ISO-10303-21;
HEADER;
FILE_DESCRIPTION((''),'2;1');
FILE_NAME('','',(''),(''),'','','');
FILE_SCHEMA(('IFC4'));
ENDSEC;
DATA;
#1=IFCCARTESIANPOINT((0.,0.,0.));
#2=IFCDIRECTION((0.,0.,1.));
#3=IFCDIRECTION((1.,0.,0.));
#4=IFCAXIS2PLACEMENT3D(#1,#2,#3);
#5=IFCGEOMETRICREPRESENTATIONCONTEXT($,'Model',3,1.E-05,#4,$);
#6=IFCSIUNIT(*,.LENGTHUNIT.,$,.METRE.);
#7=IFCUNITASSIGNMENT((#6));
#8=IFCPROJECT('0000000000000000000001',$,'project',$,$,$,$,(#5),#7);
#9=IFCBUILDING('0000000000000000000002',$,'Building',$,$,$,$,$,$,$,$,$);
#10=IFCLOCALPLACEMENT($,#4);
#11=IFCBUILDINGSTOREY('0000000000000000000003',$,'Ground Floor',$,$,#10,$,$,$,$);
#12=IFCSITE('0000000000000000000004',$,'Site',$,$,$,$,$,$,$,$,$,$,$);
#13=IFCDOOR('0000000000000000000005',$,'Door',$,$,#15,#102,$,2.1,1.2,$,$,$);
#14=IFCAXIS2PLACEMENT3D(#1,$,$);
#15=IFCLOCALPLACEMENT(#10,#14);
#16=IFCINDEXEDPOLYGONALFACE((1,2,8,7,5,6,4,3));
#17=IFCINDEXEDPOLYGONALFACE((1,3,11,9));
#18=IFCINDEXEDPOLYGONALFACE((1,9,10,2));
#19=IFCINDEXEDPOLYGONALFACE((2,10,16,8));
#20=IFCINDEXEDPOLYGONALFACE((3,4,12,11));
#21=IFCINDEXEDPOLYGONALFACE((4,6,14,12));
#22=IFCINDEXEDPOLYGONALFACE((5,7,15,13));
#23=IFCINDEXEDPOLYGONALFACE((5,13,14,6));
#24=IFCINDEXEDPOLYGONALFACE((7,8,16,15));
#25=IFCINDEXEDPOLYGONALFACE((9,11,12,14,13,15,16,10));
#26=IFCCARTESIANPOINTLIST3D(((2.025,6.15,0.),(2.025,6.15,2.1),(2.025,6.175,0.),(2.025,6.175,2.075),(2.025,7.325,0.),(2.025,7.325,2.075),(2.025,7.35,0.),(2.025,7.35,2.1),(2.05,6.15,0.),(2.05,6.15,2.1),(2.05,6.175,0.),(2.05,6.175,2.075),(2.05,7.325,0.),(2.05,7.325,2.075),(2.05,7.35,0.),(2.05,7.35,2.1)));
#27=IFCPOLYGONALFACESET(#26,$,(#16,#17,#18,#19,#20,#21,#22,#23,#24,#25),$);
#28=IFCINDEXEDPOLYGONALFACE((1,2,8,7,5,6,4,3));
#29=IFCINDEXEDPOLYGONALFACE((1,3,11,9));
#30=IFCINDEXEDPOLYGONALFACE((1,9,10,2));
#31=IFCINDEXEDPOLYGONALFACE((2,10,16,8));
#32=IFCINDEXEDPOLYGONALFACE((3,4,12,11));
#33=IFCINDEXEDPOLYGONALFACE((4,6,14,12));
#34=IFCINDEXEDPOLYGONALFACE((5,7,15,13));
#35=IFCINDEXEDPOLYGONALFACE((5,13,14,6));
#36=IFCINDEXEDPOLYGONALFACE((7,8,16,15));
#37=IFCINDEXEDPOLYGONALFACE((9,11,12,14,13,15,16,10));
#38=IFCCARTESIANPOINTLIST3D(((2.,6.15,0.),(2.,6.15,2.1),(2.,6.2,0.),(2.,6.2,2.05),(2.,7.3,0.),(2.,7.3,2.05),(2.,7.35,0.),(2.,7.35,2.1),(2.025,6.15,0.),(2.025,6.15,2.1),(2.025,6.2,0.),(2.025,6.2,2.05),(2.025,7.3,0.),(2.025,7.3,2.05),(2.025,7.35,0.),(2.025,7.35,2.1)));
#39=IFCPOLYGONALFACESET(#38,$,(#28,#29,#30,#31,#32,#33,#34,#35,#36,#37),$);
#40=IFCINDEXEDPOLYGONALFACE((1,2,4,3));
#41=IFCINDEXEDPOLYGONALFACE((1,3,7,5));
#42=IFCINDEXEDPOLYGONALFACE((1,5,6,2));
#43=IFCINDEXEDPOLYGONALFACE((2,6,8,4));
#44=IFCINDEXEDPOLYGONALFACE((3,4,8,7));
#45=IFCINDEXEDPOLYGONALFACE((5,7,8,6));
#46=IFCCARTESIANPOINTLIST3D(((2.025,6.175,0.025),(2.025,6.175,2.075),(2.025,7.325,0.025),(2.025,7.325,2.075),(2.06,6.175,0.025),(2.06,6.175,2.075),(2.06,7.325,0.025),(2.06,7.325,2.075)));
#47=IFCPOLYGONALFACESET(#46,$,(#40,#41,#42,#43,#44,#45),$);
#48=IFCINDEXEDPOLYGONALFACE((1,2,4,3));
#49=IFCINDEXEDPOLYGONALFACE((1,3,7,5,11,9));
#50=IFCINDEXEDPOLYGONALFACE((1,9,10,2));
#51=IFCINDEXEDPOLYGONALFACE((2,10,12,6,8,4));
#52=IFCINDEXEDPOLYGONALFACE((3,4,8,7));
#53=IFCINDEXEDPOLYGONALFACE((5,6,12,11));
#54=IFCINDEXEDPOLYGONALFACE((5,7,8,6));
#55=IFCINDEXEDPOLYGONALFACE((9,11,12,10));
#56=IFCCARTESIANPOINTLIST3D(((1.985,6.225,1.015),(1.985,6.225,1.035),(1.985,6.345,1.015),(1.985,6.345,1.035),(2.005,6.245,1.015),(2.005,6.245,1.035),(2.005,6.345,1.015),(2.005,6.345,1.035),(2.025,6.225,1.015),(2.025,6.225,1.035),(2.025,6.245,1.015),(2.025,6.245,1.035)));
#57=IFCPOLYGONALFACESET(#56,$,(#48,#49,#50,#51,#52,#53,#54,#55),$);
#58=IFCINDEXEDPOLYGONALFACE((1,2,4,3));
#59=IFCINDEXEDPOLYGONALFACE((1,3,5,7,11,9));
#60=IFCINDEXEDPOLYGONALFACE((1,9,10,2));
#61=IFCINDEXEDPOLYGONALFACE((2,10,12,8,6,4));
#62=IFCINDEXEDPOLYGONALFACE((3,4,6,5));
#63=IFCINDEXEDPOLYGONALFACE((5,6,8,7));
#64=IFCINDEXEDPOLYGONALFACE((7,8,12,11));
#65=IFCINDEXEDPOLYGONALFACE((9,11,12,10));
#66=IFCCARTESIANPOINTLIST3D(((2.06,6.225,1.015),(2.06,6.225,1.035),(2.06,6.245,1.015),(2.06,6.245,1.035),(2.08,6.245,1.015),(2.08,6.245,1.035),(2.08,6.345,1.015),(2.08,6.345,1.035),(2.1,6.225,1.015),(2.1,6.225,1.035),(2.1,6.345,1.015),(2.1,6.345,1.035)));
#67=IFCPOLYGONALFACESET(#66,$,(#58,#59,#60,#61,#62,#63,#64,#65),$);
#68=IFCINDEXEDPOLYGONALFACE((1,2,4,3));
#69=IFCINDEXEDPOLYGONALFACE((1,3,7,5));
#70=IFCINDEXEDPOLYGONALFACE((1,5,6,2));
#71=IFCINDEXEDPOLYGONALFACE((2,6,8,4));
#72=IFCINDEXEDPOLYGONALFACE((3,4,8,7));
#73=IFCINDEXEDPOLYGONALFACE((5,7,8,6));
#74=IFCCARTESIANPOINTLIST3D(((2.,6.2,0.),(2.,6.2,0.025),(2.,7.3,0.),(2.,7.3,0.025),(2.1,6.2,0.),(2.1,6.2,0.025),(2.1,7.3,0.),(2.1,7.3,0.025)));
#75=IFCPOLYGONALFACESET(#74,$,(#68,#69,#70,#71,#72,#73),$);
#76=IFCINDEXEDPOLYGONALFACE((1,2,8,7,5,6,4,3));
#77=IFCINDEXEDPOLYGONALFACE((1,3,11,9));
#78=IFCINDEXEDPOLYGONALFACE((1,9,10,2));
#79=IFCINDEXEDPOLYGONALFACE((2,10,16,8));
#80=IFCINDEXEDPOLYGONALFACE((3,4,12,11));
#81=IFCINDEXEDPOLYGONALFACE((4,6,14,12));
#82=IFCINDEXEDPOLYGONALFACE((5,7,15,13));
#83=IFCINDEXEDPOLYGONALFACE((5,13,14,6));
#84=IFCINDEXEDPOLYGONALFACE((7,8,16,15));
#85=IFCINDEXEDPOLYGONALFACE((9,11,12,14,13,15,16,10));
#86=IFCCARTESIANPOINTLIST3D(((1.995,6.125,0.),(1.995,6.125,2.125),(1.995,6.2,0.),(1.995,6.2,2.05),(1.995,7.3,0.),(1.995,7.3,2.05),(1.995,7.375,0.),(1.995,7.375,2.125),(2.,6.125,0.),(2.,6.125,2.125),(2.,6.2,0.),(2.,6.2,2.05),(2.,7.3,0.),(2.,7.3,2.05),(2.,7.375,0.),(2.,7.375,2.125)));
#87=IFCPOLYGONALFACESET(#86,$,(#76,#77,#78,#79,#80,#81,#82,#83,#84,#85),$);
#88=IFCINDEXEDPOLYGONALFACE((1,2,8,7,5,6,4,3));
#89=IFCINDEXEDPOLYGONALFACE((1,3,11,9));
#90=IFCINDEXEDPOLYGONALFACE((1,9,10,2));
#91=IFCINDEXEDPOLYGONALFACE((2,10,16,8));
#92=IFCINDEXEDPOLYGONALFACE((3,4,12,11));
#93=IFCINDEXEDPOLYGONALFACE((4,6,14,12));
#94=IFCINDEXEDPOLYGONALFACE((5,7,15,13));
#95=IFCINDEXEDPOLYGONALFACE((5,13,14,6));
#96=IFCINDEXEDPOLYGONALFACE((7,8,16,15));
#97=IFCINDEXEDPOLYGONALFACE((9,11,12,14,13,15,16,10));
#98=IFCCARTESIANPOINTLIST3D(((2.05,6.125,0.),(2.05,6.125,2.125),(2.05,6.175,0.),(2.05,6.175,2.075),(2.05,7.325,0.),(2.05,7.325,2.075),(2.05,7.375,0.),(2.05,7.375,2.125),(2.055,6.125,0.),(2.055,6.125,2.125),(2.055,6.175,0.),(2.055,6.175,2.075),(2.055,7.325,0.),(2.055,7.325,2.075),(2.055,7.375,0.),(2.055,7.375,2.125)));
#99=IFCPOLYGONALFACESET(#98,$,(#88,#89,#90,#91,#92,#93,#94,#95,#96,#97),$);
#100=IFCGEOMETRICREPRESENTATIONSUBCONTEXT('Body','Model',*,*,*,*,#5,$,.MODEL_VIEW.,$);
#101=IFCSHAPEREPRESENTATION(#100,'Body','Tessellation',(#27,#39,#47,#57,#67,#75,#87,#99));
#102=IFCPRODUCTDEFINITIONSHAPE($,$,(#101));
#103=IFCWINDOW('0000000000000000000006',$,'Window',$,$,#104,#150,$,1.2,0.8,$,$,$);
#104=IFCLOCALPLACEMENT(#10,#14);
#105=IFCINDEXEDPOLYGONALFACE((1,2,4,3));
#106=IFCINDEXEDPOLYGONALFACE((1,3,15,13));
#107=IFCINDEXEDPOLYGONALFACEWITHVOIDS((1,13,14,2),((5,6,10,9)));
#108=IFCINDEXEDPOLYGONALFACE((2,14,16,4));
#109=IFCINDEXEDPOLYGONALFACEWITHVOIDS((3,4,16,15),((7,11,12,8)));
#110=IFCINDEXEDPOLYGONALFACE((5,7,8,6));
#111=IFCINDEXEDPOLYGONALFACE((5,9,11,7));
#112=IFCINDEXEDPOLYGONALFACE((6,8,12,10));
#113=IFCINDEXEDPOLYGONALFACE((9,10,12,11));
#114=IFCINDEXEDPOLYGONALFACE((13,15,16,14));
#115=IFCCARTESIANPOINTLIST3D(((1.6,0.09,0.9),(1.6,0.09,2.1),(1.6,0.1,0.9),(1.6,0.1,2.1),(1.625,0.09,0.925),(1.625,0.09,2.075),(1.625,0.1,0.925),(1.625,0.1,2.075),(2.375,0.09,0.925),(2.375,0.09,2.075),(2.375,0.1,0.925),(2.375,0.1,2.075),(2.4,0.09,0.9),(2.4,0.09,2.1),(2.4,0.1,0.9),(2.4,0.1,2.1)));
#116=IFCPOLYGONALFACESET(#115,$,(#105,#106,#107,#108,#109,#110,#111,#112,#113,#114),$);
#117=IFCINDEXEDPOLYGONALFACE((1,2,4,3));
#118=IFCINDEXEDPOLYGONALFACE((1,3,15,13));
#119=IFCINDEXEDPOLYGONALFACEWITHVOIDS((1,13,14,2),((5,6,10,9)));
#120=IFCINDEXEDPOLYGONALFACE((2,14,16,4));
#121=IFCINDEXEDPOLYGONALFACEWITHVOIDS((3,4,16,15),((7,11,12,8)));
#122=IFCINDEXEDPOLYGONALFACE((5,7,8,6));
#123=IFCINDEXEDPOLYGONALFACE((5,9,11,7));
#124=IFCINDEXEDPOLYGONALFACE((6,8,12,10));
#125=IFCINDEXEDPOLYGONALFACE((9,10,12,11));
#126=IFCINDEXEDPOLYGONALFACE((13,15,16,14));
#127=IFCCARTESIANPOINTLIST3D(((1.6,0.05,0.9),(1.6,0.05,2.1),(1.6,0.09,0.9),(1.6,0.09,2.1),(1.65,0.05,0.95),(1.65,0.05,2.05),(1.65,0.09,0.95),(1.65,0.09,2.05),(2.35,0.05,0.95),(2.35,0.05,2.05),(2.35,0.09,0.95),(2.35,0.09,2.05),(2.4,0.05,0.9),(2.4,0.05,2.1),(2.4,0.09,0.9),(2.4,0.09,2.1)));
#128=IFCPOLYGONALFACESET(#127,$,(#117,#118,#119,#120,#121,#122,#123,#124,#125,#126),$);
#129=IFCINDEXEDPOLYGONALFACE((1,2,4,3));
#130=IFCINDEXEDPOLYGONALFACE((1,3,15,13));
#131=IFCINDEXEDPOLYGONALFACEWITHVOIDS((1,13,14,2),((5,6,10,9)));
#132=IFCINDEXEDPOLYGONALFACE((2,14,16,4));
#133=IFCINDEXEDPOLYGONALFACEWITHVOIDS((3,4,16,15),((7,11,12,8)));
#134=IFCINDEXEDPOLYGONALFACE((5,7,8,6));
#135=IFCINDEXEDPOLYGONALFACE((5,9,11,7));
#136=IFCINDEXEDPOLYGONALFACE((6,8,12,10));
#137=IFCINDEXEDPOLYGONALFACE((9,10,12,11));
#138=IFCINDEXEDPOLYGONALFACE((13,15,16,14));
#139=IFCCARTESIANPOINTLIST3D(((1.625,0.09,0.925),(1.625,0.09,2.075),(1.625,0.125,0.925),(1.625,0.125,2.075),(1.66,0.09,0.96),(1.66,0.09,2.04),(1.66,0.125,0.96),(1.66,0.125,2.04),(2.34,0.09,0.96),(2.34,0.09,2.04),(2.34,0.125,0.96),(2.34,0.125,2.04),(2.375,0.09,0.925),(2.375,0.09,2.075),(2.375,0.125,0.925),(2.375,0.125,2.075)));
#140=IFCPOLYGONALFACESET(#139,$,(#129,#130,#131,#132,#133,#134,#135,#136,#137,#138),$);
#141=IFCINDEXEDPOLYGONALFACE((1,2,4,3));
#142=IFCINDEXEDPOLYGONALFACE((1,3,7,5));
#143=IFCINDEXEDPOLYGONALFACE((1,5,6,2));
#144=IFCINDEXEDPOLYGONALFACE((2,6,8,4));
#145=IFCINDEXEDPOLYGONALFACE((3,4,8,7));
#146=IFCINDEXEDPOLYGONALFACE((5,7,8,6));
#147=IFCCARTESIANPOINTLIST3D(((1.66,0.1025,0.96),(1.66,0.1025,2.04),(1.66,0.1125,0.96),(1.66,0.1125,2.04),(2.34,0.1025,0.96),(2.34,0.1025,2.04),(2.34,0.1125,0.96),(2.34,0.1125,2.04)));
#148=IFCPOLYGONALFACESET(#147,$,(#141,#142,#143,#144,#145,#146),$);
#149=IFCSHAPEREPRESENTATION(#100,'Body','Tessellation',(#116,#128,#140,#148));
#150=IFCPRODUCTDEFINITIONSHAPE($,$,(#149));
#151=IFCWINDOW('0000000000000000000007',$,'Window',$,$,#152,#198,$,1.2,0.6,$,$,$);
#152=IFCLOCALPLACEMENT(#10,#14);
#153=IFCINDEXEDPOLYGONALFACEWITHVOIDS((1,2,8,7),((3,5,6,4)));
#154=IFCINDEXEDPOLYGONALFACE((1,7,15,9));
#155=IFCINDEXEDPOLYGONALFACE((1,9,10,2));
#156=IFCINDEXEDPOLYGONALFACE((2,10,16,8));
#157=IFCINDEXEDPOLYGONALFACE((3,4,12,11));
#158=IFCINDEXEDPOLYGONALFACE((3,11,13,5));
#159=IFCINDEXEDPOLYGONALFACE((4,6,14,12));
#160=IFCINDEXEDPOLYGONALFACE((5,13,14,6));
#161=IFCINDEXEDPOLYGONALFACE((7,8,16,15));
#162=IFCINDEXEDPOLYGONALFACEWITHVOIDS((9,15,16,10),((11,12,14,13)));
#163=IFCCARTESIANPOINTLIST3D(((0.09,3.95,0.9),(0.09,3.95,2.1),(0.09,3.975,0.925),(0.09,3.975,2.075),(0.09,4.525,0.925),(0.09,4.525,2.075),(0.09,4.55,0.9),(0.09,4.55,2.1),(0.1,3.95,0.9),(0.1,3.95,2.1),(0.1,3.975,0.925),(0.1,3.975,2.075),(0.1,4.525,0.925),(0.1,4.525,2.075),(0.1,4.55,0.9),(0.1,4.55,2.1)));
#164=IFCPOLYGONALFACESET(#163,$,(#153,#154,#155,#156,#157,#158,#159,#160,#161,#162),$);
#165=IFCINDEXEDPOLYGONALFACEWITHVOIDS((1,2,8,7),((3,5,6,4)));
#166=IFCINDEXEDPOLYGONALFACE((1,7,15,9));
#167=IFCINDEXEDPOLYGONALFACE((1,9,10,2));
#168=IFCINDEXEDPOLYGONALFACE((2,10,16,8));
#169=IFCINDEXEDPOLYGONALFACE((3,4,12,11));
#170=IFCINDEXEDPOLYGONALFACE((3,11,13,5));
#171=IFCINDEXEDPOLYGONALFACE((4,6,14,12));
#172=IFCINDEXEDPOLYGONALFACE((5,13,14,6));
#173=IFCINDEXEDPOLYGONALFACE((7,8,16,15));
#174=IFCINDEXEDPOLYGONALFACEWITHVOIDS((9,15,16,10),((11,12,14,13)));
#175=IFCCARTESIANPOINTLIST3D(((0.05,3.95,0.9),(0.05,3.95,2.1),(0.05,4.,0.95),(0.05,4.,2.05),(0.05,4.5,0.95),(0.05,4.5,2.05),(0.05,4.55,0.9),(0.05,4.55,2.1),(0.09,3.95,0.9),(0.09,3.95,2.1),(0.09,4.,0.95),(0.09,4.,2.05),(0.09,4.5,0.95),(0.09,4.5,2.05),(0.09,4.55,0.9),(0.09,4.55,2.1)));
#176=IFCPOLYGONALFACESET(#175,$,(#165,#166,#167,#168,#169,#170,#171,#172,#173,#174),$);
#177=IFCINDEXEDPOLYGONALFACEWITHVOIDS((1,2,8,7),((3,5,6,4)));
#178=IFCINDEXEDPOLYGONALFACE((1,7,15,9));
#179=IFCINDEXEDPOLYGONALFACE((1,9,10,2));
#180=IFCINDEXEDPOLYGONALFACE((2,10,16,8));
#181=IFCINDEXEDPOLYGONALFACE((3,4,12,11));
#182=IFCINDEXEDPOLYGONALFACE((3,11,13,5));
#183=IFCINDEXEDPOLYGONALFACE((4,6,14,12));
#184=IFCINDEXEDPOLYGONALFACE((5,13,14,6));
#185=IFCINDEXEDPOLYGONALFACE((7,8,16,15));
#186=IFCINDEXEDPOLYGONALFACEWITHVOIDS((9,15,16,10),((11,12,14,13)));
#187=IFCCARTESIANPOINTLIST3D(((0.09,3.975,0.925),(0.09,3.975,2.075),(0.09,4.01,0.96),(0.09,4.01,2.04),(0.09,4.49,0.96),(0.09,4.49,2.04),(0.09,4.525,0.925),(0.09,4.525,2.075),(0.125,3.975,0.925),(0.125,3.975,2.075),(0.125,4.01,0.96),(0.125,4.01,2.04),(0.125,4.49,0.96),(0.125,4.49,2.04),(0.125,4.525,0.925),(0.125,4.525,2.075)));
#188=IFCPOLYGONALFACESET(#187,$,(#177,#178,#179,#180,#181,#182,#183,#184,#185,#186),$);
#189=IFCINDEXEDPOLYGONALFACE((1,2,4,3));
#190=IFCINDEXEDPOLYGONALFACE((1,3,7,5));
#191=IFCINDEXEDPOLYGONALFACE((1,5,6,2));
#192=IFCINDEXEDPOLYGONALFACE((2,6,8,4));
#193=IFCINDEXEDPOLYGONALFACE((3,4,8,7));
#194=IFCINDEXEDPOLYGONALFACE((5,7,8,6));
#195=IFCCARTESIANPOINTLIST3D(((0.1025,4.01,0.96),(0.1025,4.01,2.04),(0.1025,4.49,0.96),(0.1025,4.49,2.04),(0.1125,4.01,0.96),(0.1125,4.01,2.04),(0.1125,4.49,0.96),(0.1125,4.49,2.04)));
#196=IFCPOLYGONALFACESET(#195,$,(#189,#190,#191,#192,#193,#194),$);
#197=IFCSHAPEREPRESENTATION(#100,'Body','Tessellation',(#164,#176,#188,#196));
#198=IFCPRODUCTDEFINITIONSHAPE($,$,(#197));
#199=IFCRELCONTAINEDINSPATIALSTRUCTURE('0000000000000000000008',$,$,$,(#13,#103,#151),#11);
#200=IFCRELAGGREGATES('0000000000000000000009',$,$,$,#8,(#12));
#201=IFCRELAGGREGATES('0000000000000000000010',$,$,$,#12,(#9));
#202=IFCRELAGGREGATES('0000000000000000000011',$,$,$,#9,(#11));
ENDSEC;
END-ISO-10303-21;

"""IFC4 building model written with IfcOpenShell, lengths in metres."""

from ifc_helpers import new_model, si_unit, frame, origin_with_axes, place, context, subcontext, project, spatial, line, indexed_curve, outline, extrude, element, save


model = new_model("IFC4")

# Units and contexts
model_context = context("Model", 3, precision=1e-05, world=origin_with_axes())
body_context = subcontext(model_context, "Body", "Model", "MODEL_VIEW")
ifc_project = project(units=[si_unit("LENGTHUNIT", "METRE")], contexts=[model_context])

# Site, building, storey
site = spatial("IfcSite", under=ifc_project, Name="Site")
building = spatial("IfcBuilding", under=site, Name="Building")
storey_placement = place(None, origin_with_axes())
storey = spatial("IfcBuildingStorey", under=building, at=storey_placement, Name="Ground Floor")

# Door
door_1_placement = place(storey_placement, frame((2.0, 7.35, 0.0), z_axis=(0.0, 0.0, 1.0), x_axis=(0.0, -1.0, 0.0)))
element("IfcDoor", 1, at=door_1_placement, inside=storey, Name="Door", OverallHeight=2.1, OverallWidth=1.2, context=body_context, shape_type="SweptSolid", body=[
    extrude(outline(indexed_curve([(0.0, 0.0), (0.0, 2.1), (1.2, 2.1), (1.2, 0.0), (1.175, 0.0), (1.175, 2.075), (0.025, 2.075), (0.025, 0.0)], segments=[line(1, 2, 3, 4, 5, 6, 7, 8, 1)])), frame((0.0, 0.025, 0.0), z_axis=(0.0, -1.0, 0.0), x_axis=(1.0, 0.0, 0.0)), (0.0, 0.0, -1.0), 0.025),
    extrude(outline(indexed_curve([(0.0, 0.0), (0.0, 2.1), (1.2, 2.1), (1.2, 0.0), (1.15, 0.0), (1.15, 2.05), (0.05, 2.05), (0.05, 0.0)], segments=[line(1, 2, 3, 4, 5, 6, 7, 8, 1)])), frame((0.0, 0.0, 0.0), z_axis=(0.0, -1.0, 0.0), x_axis=(1.0, 0.0, 0.0)), (0.0, 0.0, -1.0), 0.025),
    extrude(outline(indexed_curve([(0.0, 0.0), (1.15, 0.0), (1.15, 0.035), (0.0, 0.035)], segments=[line(1, 2, 3, 4, 1)])), frame((0.025, 0.025, 0.025), z_axis=(0.0, 0.0, 1.0), x_axis=(1.0, 0.0, 0.0)), (0.0, 0.0, 1.0), 2.05),
    extrude(outline(indexed_curve([(0.0, 0.0), (0.0, -0.04), (-0.12, -0.04), (-0.12, -0.02), (-0.02, -0.02), (-0.02, 0.0)], segments=[line(1, 2, 3, 4, 5, 6, 1)])), frame((1.125, 0.025, 1.015), z_axis=(0.0, 0.0, 1.0), x_axis=(1.0, 0.0, 0.0)), (0.0, 0.0, 1.0), 0.02),
    extrude(outline(indexed_curve([(0.0, 0.0), (0.0, 0.04), (-0.12, 0.04), (-0.12, 0.02), (-0.02, 0.02), (-0.02, 0.0)], segments=[line(1, 2, 3, 4, 5, 6, 1)])), frame((1.125, 0.06, 1.015), z_axis=(0.0, 0.0, 1.0), x_axis=(1.0, 0.0, 0.0)), (0.0, 0.0, 1.0), 0.02),
    extrude(outline(indexed_curve([(0.0, 0.0), (1.1, 0.0), (1.1, 0.1), (0.0, 0.1)], segments=[line(1, 2, 3, 4, 1)])), frame((0.05, 0.0, 0.0), z_axis=(0.0, 0.0, 1.0), x_axis=(1.0, 0.0, 0.0)), (0.0, 0.0, 1.0), 0.025),
    extrude(outline(indexed_curve([(0.0, 0.0), (0.0, 2.125), (1.25, 2.125), (1.25, 0.0), (1.175, 0.0), (1.175, 2.05), (0.075, 2.05), (0.075, 0.0)], segments=[line(1, 2, 3, 4, 5, 6, 7, 8, 1)])), frame((-0.025, -0.005, 0.0), z_axis=(0.0, -1.0, 0.0), x_axis=(1.0, 0.0, 0.0)), (0.0, 0.0, -1.0), 0.005),
    extrude(outline(indexed_curve([(0.0, 0.0), (0.0, 2.125), (1.25, 2.125), (1.25, 0.0), (1.2, 0.0), (1.2, 2.075), (0.05, 2.075), (0.05, 0.0)], segments=[line(1, 2, 3, 4, 5, 6, 7, 8, 1)])), frame((-0.025, 0.05, 0.0), z_axis=(0.0, -1.0, 0.0), x_axis=(1.0, 0.0, 0.0)), (0.0, 0.0, -1.0), 0.005),
])

# Windows
window_1_placement = place(storey_placement, frame((1.6, 0.0, 0.9), z_axis=(0.0, 0.0, 1.0), x_axis=(1.0, 0.0, 0.0)))
element("IfcWindow", 2, at=window_1_placement, inside=storey, Name="Window", OverallHeight=1.2, OverallWidth=0.8, context=body_context, shape_type="SweptSolid", body=[
    extrude(outline(indexed_curve([(0.0, 0.0), (0.8, 0.0), (0.8, 1.2), (0.0, 1.2)], segments=[line(1, 2, 3, 4, 1)]), holes=[indexed_curve([(0.025, 0.025), (0.775, 0.025), (0.775, 1.175), (0.025, 1.175)], segments=[line(1, 2, 3, 4, 1)])]), frame((0.0, 0.09, 0.0), z_axis=(0.0, -1.0, 0.0), x_axis=(1.0, 0.0, 0.0)), (0.0, 0.0, -1.0), 0.01),
    extrude(outline(indexed_curve([(0.0, 0.0), (0.8, 0.0), (0.8, 1.2), (0.0, 1.2)], segments=[line(1, 2, 3, 4, 1)]), holes=[indexed_curve([(0.05, 0.05), (0.75, 0.05), (0.75, 1.15), (0.05, 1.15)], segments=[line(1, 2, 3, 4, 1)])]), frame((0.0, 0.05, 0.0), z_axis=(0.0, -1.0, 0.0), x_axis=(1.0, 0.0, 0.0)), (0.0, 0.0, -1.0), 0.04),
    extrude(outline(indexed_curve([(0.0, 0.0), (0.75, 0.0), (0.75, 1.15), (0.0, 1.15)], segments=[line(1, 2, 3, 4, 1)]), holes=[indexed_curve([(0.035, 0.035), (0.715, 0.035), (0.715, 1.115), (0.035, 1.115)], segments=[line(1, 2, 3, 4, 1)])]), frame((0.025, 0.09, 0.025), z_axis=(0.0, -1.0, 0.0), x_axis=(1.0, 0.0, 0.0)), (0.0, 0.0, -1.0), 0.035),
    extrude(outline(indexed_curve([(0.035, 0.035), (0.715, 0.035), (0.715, 1.115), (0.035, 1.115)], segments=[line(1, 2, 3, 4, 1)])), frame((0.025, 0.1025, 0.025), z_axis=(0.0, -1.0, 0.0), x_axis=(1.0, 0.0, 0.0)), (0.0, 0.0, -1.0), 0.01),
])
window_2_placement = place(storey_placement, frame((0.0, 4.55, 0.9), z_axis=(0.0, 0.0, 1.0), x_axis=(0.0, -1.0, 0.0)))
element("IfcWindow", 3, at=window_2_placement, inside=storey, Name="Window", OverallHeight=1.2, OverallWidth=0.6, context=body_context, shape_type="SweptSolid", body=[
    extrude(outline(indexed_curve([(0.0, 0.0), (0.6, 0.0), (0.6, 1.2), (0.0, 1.2)], segments=[line(1, 2, 3, 4, 1)]), holes=[indexed_curve([(0.025, 0.025), (0.575, 0.025), (0.575, 1.175), (0.025, 1.175)], segments=[line(1, 2, 3, 4, 1)])]), frame((0.0, 0.09, 0.0), z_axis=(0.0, -1.0, 0.0), x_axis=(1.0, 0.0, 0.0)), (0.0, 0.0, -1.0), 0.01),
    extrude(outline(indexed_curve([(0.0, 0.0), (0.6, 0.0), (0.6, 1.2), (0.0, 1.2)], segments=[line(1, 2, 3, 4, 1)]), holes=[indexed_curve([(0.05, 0.05), (0.55, 0.05), (0.55, 1.15), (0.05, 1.15)], segments=[line(1, 2, 3, 4, 1)])]), frame((0.0, 0.05, 0.0), z_axis=(0.0, -1.0, 0.0), x_axis=(1.0, 0.0, 0.0)), (0.0, 0.0, -1.0), 0.04),
    extrude(outline(indexed_curve([(0.0, 0.0), (0.55, 0.0), (0.55, 1.15), (0.0, 1.15)], segments=[line(1, 2, 3, 4, 1)]), holes=[indexed_curve([(0.035, 0.035), (0.515, 0.035), (0.515, 1.115), (0.035, 1.115)], segments=[line(1, 2, 3, 4, 1)])]), frame((0.025, 0.09, 0.025), z_axis=(0.0, -1.0, 0.0), x_axis=(1.0, 0.0, 0.0)), (0.0, 0.0, -1.0), 0.035),
    extrude(outline(indexed_curve([(0.035, 0.035), (0.515, 0.035), (0.515, 1.115), (0.035, 1.115)], segments=[line(1, 2, 3, 4, 1)])), frame((0.025, 0.1025, 0.025), z_axis=(0.0, -1.0, 0.0), x_axis=(1.0, 0.0, 0.0)), (0.0, 0.0, -1.0), 0.01),
])

save(model, "model.ifc")
